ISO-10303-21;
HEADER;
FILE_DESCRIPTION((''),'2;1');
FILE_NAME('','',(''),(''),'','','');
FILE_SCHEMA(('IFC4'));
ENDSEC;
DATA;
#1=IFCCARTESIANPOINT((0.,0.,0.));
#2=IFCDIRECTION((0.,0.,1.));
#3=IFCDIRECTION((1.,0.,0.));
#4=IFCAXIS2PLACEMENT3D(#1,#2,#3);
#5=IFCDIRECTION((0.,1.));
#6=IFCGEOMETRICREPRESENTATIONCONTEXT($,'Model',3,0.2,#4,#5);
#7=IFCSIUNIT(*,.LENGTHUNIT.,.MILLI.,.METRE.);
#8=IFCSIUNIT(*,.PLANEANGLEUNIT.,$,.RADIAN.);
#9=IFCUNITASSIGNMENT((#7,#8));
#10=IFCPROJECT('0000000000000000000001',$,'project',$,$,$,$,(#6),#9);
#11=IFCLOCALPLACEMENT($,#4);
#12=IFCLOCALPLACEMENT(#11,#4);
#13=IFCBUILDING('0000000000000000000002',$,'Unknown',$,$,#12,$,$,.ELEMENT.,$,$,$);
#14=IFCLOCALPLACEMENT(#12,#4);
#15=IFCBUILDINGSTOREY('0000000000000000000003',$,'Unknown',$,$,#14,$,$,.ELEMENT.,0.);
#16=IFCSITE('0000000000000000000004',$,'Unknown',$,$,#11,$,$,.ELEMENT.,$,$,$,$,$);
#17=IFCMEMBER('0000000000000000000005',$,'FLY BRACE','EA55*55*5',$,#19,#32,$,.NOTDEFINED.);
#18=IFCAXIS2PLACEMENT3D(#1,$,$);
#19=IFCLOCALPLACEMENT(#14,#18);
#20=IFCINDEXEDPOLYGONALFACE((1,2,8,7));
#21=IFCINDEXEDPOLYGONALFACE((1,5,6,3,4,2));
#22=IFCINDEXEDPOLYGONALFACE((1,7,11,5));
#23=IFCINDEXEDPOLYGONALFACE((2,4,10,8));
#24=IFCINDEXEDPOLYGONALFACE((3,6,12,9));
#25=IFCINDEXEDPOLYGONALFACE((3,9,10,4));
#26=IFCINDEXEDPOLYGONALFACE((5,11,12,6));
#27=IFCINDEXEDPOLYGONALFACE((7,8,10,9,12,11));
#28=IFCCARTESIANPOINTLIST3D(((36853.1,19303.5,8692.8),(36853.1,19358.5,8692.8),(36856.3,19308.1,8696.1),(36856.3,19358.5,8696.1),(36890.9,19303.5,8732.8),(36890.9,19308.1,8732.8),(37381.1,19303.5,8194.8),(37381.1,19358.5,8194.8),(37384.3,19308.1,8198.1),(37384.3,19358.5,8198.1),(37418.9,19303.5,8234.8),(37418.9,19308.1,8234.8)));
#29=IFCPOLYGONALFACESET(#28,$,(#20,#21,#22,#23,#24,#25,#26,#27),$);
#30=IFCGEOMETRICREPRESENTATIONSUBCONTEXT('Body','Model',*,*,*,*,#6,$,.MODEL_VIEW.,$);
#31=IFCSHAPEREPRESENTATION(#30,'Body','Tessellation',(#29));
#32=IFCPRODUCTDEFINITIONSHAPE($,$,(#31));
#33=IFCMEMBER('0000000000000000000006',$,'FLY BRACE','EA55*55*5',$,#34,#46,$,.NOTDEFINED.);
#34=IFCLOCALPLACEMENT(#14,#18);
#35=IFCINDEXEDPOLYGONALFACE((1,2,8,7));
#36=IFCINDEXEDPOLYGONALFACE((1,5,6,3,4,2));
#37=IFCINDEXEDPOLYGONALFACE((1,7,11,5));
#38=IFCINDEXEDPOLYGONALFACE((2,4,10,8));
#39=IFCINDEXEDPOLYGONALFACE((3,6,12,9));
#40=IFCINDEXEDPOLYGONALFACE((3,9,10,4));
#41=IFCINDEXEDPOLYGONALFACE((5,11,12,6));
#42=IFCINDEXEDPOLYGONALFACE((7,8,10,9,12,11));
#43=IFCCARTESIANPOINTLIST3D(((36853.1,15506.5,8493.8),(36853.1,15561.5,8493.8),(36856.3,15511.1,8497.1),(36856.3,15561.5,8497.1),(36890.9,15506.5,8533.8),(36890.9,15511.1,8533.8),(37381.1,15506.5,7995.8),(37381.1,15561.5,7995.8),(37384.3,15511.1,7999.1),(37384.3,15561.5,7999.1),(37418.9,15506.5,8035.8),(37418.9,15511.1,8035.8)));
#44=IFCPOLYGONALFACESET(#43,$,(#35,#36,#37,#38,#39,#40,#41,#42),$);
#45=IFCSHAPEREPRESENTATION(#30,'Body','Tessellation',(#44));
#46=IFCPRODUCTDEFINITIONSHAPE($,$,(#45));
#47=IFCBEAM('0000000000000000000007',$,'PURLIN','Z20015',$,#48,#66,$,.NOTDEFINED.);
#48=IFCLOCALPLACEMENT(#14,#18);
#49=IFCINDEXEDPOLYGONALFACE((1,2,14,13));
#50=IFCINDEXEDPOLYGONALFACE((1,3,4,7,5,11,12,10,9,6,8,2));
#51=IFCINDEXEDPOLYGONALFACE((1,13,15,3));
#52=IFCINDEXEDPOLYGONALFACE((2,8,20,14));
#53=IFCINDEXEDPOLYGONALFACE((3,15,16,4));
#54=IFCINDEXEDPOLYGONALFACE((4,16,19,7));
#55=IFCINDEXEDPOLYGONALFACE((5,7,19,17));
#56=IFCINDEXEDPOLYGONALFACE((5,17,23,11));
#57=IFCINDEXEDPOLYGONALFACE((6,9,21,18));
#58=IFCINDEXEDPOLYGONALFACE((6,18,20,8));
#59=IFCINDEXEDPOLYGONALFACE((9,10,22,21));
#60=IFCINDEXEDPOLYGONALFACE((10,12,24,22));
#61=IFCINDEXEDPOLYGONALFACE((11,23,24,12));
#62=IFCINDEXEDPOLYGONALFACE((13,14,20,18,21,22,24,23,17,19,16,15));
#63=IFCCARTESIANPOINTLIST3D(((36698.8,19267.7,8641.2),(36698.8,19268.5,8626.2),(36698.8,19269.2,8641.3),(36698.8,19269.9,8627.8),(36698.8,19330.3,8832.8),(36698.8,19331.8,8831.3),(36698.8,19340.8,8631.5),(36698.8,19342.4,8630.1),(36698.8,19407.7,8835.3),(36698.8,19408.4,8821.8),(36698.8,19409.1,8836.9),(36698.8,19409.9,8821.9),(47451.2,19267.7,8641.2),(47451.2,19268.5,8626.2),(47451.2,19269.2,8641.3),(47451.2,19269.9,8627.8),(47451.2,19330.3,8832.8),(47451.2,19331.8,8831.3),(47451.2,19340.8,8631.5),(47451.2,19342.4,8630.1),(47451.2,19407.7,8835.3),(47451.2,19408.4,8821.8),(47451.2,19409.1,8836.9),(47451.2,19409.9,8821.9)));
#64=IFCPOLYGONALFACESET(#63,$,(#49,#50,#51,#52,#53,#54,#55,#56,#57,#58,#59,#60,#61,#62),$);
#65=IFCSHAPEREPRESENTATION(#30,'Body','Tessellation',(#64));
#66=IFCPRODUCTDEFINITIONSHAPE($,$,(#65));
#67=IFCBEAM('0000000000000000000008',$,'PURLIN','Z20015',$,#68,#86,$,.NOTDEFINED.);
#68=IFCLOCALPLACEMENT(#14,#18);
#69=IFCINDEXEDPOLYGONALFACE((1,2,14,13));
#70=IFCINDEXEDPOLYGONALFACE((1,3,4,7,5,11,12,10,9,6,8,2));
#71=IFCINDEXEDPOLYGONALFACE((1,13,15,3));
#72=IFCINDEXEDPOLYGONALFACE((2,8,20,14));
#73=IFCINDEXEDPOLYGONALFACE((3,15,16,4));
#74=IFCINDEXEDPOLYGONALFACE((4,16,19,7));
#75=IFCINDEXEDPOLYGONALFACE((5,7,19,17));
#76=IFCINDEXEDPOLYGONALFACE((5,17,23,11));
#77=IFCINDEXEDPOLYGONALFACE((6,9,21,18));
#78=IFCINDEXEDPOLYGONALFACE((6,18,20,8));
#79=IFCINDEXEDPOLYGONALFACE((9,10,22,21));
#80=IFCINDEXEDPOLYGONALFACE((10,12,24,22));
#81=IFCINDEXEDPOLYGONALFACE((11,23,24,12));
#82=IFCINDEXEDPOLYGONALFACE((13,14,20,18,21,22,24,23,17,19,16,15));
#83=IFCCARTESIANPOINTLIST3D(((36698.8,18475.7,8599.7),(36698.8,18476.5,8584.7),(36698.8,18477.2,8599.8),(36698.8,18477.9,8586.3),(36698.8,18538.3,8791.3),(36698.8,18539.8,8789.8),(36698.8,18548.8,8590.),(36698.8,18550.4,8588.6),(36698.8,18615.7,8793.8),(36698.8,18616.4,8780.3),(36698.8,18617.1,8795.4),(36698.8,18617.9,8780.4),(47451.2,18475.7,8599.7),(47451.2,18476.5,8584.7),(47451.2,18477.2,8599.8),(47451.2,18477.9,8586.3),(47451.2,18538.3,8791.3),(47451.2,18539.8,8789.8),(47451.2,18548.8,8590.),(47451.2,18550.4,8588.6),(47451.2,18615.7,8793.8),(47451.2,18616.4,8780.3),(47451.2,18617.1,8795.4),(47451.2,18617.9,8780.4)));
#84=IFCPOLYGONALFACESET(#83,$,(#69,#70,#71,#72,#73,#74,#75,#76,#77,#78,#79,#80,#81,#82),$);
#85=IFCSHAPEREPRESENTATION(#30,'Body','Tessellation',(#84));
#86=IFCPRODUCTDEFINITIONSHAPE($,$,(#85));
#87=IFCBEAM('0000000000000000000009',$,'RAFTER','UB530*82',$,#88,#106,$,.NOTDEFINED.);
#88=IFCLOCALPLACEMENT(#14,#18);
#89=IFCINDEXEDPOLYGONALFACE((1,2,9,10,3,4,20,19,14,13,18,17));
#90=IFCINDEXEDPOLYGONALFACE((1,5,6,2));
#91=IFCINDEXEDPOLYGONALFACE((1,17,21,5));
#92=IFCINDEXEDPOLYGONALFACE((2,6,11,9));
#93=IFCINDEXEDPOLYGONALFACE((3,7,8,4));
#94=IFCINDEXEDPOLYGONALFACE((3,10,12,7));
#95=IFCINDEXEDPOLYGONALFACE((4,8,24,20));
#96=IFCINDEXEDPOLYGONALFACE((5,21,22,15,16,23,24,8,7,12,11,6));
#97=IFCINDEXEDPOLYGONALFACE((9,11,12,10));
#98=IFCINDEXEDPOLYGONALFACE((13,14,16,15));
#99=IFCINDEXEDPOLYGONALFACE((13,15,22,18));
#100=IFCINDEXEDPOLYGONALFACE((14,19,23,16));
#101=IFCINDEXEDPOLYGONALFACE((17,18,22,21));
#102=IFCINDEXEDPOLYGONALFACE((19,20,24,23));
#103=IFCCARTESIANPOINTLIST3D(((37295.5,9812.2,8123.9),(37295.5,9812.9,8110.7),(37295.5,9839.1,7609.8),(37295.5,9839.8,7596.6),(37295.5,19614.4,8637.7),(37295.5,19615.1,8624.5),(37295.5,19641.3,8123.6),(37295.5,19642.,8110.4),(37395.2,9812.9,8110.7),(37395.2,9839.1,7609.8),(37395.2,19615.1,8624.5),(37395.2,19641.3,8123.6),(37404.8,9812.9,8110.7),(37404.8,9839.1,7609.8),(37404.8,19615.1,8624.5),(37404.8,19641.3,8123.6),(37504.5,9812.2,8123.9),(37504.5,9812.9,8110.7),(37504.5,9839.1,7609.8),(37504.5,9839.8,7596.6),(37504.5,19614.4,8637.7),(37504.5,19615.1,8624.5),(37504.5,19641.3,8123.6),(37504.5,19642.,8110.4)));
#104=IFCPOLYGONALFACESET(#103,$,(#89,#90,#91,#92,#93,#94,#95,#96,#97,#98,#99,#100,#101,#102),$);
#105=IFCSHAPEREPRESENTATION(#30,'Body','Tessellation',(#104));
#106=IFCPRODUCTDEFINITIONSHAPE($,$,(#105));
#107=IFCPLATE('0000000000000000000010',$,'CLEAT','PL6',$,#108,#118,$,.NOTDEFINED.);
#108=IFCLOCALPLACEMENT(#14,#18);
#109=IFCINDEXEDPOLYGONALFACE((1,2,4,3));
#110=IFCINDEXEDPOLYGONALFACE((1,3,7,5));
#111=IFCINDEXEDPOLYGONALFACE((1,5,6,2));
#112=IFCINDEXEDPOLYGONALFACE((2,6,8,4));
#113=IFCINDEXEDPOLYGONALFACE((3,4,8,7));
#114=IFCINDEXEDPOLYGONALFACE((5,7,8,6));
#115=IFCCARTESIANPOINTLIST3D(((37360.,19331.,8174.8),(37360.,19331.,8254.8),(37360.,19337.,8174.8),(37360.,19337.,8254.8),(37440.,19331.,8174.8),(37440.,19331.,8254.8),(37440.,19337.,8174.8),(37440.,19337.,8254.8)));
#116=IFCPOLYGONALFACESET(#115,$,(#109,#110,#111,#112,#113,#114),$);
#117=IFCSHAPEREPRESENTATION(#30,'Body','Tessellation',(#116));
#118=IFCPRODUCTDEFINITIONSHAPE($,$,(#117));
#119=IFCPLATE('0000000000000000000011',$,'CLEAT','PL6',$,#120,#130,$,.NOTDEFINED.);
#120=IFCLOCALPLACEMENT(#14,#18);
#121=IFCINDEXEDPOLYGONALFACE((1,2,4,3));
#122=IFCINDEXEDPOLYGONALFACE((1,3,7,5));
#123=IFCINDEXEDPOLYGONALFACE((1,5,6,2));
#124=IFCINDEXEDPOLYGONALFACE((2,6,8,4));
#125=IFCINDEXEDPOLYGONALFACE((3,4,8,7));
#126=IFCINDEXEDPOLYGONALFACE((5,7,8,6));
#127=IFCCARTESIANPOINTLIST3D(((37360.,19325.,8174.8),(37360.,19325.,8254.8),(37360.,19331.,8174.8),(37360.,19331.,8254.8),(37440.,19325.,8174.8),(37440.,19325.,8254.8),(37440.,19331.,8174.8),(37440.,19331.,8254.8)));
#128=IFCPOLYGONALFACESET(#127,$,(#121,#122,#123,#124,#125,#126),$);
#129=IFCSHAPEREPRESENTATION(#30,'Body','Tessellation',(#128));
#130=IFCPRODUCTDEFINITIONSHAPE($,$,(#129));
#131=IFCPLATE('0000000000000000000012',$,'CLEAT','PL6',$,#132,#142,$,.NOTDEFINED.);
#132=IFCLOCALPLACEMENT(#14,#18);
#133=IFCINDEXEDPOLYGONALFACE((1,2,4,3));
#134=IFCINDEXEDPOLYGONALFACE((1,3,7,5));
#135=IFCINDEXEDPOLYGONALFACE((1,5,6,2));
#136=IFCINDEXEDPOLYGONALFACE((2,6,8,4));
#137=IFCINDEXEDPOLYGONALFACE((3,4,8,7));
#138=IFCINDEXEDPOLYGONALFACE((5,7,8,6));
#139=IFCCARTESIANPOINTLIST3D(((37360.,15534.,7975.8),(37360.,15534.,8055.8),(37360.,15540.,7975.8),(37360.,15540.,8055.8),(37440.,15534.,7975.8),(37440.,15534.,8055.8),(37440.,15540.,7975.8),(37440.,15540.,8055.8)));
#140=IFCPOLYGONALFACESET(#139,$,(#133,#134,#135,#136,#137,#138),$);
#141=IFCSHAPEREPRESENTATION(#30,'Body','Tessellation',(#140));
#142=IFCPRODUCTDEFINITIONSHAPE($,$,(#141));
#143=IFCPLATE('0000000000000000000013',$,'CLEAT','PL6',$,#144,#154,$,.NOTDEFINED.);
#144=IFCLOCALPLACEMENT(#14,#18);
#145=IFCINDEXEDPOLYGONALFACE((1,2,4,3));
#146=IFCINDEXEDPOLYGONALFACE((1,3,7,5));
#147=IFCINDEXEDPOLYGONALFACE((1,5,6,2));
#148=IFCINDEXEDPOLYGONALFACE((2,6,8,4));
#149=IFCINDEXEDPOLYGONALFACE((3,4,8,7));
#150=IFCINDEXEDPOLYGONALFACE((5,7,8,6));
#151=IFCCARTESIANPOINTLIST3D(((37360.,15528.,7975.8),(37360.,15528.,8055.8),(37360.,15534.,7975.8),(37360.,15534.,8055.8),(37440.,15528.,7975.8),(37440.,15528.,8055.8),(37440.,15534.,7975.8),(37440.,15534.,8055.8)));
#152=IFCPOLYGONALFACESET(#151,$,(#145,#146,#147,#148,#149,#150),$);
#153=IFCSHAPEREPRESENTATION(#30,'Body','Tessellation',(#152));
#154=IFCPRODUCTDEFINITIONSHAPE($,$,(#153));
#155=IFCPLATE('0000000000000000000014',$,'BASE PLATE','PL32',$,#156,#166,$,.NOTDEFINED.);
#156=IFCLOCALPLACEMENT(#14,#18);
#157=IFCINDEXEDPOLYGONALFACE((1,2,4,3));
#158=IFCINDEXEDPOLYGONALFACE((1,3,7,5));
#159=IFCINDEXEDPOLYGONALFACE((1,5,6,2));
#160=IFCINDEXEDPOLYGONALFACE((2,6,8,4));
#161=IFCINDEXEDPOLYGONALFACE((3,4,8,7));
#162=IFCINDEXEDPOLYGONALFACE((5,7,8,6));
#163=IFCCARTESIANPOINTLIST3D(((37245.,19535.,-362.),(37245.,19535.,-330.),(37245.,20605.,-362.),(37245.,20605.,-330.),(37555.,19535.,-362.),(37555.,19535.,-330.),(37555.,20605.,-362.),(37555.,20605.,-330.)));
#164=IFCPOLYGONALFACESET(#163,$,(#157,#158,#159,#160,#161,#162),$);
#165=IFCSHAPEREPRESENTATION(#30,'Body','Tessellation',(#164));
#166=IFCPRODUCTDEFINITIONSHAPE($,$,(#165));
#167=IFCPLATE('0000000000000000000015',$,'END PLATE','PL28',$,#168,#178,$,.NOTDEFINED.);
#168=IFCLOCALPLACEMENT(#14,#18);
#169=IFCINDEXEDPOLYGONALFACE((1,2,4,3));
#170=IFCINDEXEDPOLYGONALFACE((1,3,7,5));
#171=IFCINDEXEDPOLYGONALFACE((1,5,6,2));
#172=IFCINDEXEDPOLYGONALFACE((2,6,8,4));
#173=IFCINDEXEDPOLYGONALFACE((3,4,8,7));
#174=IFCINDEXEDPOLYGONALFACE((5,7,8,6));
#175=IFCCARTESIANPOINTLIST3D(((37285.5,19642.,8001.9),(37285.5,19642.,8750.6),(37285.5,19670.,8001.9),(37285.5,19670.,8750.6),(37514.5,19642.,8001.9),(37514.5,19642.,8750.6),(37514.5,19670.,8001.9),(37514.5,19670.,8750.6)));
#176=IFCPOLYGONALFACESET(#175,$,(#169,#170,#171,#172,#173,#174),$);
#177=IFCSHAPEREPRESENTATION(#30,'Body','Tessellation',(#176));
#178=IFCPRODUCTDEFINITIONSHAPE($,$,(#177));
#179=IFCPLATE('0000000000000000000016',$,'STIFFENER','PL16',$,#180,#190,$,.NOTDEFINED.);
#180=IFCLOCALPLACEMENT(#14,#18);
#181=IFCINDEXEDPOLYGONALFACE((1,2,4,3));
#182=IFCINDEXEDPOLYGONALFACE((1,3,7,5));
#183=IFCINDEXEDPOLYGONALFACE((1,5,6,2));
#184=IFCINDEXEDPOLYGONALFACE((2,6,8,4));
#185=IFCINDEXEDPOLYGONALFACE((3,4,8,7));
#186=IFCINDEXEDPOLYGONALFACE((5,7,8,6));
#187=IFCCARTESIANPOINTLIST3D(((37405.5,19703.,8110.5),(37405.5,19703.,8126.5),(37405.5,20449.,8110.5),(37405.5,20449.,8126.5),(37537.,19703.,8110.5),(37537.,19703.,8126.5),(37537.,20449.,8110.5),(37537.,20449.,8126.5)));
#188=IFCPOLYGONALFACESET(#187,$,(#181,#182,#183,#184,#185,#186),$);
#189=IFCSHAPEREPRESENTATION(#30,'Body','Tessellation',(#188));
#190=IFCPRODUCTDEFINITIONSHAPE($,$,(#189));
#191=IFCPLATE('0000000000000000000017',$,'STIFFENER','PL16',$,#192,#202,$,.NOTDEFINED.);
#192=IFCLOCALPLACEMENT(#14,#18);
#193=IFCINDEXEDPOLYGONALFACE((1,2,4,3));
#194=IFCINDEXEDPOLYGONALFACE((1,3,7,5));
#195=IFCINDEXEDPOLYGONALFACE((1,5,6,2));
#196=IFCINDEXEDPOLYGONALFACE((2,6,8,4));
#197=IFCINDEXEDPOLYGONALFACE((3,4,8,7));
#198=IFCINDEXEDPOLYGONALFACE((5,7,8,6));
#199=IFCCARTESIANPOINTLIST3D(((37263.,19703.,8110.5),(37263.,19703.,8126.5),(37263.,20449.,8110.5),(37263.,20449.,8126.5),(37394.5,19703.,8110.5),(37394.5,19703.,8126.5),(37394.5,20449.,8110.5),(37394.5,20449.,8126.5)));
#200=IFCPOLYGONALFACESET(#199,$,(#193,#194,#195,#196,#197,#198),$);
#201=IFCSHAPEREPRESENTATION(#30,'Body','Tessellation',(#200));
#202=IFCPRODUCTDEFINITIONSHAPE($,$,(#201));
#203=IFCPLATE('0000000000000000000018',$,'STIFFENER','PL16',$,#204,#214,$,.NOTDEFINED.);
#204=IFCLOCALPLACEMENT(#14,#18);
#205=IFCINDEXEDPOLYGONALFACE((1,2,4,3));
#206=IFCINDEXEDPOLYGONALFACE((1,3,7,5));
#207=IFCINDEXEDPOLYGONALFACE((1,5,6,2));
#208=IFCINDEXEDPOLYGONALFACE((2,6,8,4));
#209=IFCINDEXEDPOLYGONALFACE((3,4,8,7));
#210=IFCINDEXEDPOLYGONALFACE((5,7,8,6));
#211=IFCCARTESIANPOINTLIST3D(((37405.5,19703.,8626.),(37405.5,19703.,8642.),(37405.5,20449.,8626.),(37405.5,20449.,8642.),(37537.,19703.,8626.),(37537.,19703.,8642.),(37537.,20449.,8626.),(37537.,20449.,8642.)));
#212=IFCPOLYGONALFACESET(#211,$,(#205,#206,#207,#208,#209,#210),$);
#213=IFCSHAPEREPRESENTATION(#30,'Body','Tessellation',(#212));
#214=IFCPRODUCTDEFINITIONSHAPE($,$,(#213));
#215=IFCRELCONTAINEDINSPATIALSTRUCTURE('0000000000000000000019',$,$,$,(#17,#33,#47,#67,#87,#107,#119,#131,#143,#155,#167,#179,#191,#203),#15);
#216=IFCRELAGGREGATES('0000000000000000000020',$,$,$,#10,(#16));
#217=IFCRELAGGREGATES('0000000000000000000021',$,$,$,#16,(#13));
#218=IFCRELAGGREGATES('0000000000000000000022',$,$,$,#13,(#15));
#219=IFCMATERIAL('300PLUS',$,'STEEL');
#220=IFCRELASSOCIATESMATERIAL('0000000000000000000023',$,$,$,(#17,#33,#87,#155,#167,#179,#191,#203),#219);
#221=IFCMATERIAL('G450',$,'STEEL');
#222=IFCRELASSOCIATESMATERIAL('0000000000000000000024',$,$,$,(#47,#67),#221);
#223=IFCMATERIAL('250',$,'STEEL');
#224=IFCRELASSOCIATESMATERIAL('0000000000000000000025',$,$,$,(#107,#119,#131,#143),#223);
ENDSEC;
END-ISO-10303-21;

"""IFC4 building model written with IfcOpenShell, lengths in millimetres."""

from ifc_helpers import new_model, si_unit, direction, frame, origin_with_axes, place, context, subcontext, project, spatial, line, indexed_curve, outline, extrude, material, element, save


model = new_model("IFC4")

# Units and contexts
model_context = context("Model", 3, precision=0.2, world=origin_with_axes(), true_north=direction((0.0, 1.0)))
body_context = subcontext(model_context, "Body", "Model", "MODEL_VIEW")
ifc_project = project(units=[si_unit("LENGTHUNIT", "METRE", prefix="MILLI"), si_unit("PLANEANGLEUNIT", "RADIAN")], contexts=[model_context])

# Site, building, storey
site_placement = place(None, origin_with_axes())
site = spatial("IfcSite", under=ifc_project, at=site_placement, Name="Unknown", CompositionType="ELEMENT")
building_placement = place(site_placement, origin_with_axes())
building = spatial("IfcBuilding", under=site, at=building_placement, Name="Unknown", CompositionType="ELEMENT")
storey_placement = place(building_placement, origin_with_axes())
storey = spatial("IfcBuildingStorey", under=building, at=storey_placement, Name="Unknown", CompositionType="ELEMENT", Elevation=0.0)

# Members
ifc_material_1 = material(Name="300PLUS", Category="STEEL")
for number, where, z_axis, x_axis, name in (
    (1, (36872.0, 19331.0, 8712.8), (0.686138, 0.0, 0.727472), (0.727472, 0.0, -0.686138), "FLY BRACE"),
    (2, (36872.0, 15534.0, 8513.8), (0.686138, 0.0, 0.727472), (0.727472, 0.0, -0.686138), "FLY BRACE"),
):
    element("IfcMember", number, at=place(storey_placement, frame(where, z_axis=z_axis, x_axis=x_axis)), inside=storey, material=ifc_material_1, Name=name, Description="EA55*55*5", PredefinedType="NOTDEFINED", context=body_context, shape_type="SolidModel", body=[
        extrude(outline(indexed_curve([(-27.5, -27.5), (27.5, -27.5), (27.5, -22.9), (-22.9, -22.9), (-22.9, 27.5), (-27.5, 27.5)], segments=[line(1, 2, 3, 4, 5, 6, 1)])), frame((0.0, 0.0, 0.0), z_axis=(-1.0, 0.0, 0.0), x_axis=(0.0, 0.0, 1.0)), (0.0, 0.0, -1.0), 725.8),
    ])

# Beams
ifc_material_2 = material(Name="G450", Category="STEEL")
for number, where, z_axis, x_axis, name in (
    (3, (36698.8, 19336.3, 8731.4), (0.0, -0.99863, -0.052336), (1.0, 0.0, 0.0), "PURLIN"),
    (4, (36698.8, 18544.3, 8689.9), (0.0, -0.99863, -0.052336), (1.0, 0.0, 0.0), "PURLIN"),
):
    element("IfcBeam", number, at=place(storey_placement, frame(where, z_axis=z_axis, x_axis=x_axis)), inside=storey, material=ifc_material_2, Name=name, Description="Z20015", PredefinedType="NOTDEFINED", context=body_context, shape_type="SolidModel", body=[
        extrude(outline(indexed_curve([(73.2, -101.5), (73.2, -86.5), (71.8, -86.5), (71.8, -100.0), (0.8, -100.0), (0.8, 101.5), (-78.2, 101.5), (-78.2, 86.5), (-76.8, 86.5), (-76.8, 100.0), (-0.8, 100.0), (-0.8, -101.5)], segments=[line(1, 2, 3, 4, 5, 6, 7, 8, 9, 10, 11, 12, 1)])), frame((0.0, 0.0, 0.0), z_axis=(-1.0, 0.0, 0.0), x_axis=(0.0, 0.0, 1.0)), (0.0, 0.0, -1.0), 10752.4),
    ])
beam_placement = place(storey_placement, frame((37400.0, 19628.2, 8374.1), z_axis=(-1.0, 0.0, 0.0), x_axis=(0.0, -0.998629, -0.052345)))
element("IfcBeam", 5, at=beam_placement, inside=storey, material=ifc_material_1, Name="RAFTER", Description="UB530*82", PredefinedType="NOTDEFINED", context=body_context, shape_type="SolidModel", body=[
    extrude(outline(indexed_curve([(-104.5, -264.0), (104.5, -264.0), (104.5, -250.8), (4.8, -250.8), (4.8, 250.8), (104.5, 250.8), (104.5, 264.0), (-104.5, 264.0), (-104.5, 250.8), (-4.8, 250.8), (-4.8, -250.8), (-104.5, -250.8)], segments=[line(1, 2, 3, 4, 5, 6, 7, 8, 9, 10, 11, 12, 1)])), frame((0.0, 0.0, 0.0), z_axis=(-1.0, 0.0, 0.0), x_axis=(0.0, 0.0, 1.0)), (0.0, 0.0, -1.0), 9815.7),
])

# Plates
ifc_material_3 = material(Name="250", Category="STEEL")
for number, where, z_axis, x_axis, name in (
    (6, (37440.0, 19334.0, 8174.8), (0.0, 1.0, 0.0), (-1.0, 0.0, 0.0), "CLEAT"),
    (7, (37360.0, 19328.0, 8174.8), (0.0, -1.0, 0.0), (1.0, 0.0, 0.0), "CLEAT"),
    (8, (37440.0, 15537.0, 7975.8), (0.0, 1.0, 0.0), (-1.0, 0.0, 0.0), "CLEAT"),
    (9, (37360.0, 15531.0, 7975.8), (0.0, -1.0, 0.0), (1.0, 0.0, 0.0), "CLEAT"),
):
    element("IfcPlate", number, at=place(storey_placement, frame(where, z_axis=z_axis, x_axis=x_axis)), inside=storey, material=ifc_material_3, Name=name, Description="PL6", PredefinedType="NOTDEFINED", context=body_context, shape_type="SolidModel", body=[
        extrude(outline(indexed_curve([(0.0, 0.0), (80.0, 0.0), (80.0, 80.0), (0.0, 80.0)], segments=[line(1, 2, 3, 4, 1)])), frame((0.0, 0.0, 3.0), z_axis=(0.0, 0.0, 1.0), x_axis=(1.0, 0.0, 0.0)), (0.0, 0.0, -1.0), 6.0),
    ])
plate_1_placement = place(storey_placement, frame((37555.0, 19535.0, -346.0), z_axis=(0.0, 0.0, 1.0), x_axis=(0.0, 1.0, 0.0)))
element("IfcPlate", 10, at=plate_1_placement, inside=storey, material=ifc_material_1, Name="BASE PLATE", Description="PL32", PredefinedType="NOTDEFINED", context=body_context, shape_type="SolidModel", body=[
    extrude(outline(indexed_curve([(0.0, 0.0), (1070.0, 0.0), (1070.0, 310.0), (0.0, 310.0)], segments=[line(1, 2, 3, 4, 1)])), frame((0.0, 0.0, 16.0), z_axis=(0.0, 0.0, 1.0), x_axis=(1.0, 0.0, 0.0)), (0.0, 0.0, -1.0), 32.0),
])
plate_2_placement = place(storey_placement, frame((37514.5, 19656.0, 8750.6), z_axis=(0.0, -1.0, 0.0), x_axis=(-1.0, 0.0, 0.0)))
element("IfcPlate", 11, at=plate_2_placement, inside=storey, material=ifc_material_1, Name="END PLATE", Description="PL28", PredefinedType="NOTDEFINED", context=body_context, shape_type="SolidModel", body=[
    extrude(outline(indexed_curve([(0.0, 0.0), (229.0, 0.0), (229.0, 748.7), (0.0, 748.7)], segments=[line(1, 2, 3, 4, 1)])), frame((0.0, 0.0, 14.0), z_axis=(0.0, 0.0, 1.0), x_axis=(1.0, 0.0, 0.0)), (0.0, 0.0, -1.0), 28.0),
])
for number, where, z_axis, x_axis, name in (
    (12, (37537.0, 19703.0, 8118.5), (0.0, 0.0, 1.0), (0.0, 1.0, 0.0), "STIFFENER"),
    (13, (37394.5, 19703.0, 8118.5), (0.0, 0.0, 1.0), (0.0, 1.0, 0.0), "STIFFENER"),
    (14, (37537.0, 19703.0, 8634.0), (0.0, 0.0, 1.0), (0.0, 1.0, 0.0), "STIFFENER"),
):
    element("IfcPlate", number, at=place(storey_placement, frame(where, z_axis=z_axis, x_axis=x_axis)), inside=storey, material=ifc_material_1, Name=name, Description="PL16", PredefinedType="NOTDEFINED", context=body_context, shape_type="SolidModel", body=[
        extrude(outline(indexed_curve([(0.0, 0.0), (746.0, 0.0), (746.0, 131.5), (0.0, 131.5)], segments=[line(1, 2, 3, 4, 1)])), frame((0.0, 0.0, 8.0), z_axis=(0.0, 0.0, 1.0), x_axis=(1.0, 0.0, 0.0)), (0.0, 0.0, -1.0), 16.0),
    ])

save(model, "model.ifc")
